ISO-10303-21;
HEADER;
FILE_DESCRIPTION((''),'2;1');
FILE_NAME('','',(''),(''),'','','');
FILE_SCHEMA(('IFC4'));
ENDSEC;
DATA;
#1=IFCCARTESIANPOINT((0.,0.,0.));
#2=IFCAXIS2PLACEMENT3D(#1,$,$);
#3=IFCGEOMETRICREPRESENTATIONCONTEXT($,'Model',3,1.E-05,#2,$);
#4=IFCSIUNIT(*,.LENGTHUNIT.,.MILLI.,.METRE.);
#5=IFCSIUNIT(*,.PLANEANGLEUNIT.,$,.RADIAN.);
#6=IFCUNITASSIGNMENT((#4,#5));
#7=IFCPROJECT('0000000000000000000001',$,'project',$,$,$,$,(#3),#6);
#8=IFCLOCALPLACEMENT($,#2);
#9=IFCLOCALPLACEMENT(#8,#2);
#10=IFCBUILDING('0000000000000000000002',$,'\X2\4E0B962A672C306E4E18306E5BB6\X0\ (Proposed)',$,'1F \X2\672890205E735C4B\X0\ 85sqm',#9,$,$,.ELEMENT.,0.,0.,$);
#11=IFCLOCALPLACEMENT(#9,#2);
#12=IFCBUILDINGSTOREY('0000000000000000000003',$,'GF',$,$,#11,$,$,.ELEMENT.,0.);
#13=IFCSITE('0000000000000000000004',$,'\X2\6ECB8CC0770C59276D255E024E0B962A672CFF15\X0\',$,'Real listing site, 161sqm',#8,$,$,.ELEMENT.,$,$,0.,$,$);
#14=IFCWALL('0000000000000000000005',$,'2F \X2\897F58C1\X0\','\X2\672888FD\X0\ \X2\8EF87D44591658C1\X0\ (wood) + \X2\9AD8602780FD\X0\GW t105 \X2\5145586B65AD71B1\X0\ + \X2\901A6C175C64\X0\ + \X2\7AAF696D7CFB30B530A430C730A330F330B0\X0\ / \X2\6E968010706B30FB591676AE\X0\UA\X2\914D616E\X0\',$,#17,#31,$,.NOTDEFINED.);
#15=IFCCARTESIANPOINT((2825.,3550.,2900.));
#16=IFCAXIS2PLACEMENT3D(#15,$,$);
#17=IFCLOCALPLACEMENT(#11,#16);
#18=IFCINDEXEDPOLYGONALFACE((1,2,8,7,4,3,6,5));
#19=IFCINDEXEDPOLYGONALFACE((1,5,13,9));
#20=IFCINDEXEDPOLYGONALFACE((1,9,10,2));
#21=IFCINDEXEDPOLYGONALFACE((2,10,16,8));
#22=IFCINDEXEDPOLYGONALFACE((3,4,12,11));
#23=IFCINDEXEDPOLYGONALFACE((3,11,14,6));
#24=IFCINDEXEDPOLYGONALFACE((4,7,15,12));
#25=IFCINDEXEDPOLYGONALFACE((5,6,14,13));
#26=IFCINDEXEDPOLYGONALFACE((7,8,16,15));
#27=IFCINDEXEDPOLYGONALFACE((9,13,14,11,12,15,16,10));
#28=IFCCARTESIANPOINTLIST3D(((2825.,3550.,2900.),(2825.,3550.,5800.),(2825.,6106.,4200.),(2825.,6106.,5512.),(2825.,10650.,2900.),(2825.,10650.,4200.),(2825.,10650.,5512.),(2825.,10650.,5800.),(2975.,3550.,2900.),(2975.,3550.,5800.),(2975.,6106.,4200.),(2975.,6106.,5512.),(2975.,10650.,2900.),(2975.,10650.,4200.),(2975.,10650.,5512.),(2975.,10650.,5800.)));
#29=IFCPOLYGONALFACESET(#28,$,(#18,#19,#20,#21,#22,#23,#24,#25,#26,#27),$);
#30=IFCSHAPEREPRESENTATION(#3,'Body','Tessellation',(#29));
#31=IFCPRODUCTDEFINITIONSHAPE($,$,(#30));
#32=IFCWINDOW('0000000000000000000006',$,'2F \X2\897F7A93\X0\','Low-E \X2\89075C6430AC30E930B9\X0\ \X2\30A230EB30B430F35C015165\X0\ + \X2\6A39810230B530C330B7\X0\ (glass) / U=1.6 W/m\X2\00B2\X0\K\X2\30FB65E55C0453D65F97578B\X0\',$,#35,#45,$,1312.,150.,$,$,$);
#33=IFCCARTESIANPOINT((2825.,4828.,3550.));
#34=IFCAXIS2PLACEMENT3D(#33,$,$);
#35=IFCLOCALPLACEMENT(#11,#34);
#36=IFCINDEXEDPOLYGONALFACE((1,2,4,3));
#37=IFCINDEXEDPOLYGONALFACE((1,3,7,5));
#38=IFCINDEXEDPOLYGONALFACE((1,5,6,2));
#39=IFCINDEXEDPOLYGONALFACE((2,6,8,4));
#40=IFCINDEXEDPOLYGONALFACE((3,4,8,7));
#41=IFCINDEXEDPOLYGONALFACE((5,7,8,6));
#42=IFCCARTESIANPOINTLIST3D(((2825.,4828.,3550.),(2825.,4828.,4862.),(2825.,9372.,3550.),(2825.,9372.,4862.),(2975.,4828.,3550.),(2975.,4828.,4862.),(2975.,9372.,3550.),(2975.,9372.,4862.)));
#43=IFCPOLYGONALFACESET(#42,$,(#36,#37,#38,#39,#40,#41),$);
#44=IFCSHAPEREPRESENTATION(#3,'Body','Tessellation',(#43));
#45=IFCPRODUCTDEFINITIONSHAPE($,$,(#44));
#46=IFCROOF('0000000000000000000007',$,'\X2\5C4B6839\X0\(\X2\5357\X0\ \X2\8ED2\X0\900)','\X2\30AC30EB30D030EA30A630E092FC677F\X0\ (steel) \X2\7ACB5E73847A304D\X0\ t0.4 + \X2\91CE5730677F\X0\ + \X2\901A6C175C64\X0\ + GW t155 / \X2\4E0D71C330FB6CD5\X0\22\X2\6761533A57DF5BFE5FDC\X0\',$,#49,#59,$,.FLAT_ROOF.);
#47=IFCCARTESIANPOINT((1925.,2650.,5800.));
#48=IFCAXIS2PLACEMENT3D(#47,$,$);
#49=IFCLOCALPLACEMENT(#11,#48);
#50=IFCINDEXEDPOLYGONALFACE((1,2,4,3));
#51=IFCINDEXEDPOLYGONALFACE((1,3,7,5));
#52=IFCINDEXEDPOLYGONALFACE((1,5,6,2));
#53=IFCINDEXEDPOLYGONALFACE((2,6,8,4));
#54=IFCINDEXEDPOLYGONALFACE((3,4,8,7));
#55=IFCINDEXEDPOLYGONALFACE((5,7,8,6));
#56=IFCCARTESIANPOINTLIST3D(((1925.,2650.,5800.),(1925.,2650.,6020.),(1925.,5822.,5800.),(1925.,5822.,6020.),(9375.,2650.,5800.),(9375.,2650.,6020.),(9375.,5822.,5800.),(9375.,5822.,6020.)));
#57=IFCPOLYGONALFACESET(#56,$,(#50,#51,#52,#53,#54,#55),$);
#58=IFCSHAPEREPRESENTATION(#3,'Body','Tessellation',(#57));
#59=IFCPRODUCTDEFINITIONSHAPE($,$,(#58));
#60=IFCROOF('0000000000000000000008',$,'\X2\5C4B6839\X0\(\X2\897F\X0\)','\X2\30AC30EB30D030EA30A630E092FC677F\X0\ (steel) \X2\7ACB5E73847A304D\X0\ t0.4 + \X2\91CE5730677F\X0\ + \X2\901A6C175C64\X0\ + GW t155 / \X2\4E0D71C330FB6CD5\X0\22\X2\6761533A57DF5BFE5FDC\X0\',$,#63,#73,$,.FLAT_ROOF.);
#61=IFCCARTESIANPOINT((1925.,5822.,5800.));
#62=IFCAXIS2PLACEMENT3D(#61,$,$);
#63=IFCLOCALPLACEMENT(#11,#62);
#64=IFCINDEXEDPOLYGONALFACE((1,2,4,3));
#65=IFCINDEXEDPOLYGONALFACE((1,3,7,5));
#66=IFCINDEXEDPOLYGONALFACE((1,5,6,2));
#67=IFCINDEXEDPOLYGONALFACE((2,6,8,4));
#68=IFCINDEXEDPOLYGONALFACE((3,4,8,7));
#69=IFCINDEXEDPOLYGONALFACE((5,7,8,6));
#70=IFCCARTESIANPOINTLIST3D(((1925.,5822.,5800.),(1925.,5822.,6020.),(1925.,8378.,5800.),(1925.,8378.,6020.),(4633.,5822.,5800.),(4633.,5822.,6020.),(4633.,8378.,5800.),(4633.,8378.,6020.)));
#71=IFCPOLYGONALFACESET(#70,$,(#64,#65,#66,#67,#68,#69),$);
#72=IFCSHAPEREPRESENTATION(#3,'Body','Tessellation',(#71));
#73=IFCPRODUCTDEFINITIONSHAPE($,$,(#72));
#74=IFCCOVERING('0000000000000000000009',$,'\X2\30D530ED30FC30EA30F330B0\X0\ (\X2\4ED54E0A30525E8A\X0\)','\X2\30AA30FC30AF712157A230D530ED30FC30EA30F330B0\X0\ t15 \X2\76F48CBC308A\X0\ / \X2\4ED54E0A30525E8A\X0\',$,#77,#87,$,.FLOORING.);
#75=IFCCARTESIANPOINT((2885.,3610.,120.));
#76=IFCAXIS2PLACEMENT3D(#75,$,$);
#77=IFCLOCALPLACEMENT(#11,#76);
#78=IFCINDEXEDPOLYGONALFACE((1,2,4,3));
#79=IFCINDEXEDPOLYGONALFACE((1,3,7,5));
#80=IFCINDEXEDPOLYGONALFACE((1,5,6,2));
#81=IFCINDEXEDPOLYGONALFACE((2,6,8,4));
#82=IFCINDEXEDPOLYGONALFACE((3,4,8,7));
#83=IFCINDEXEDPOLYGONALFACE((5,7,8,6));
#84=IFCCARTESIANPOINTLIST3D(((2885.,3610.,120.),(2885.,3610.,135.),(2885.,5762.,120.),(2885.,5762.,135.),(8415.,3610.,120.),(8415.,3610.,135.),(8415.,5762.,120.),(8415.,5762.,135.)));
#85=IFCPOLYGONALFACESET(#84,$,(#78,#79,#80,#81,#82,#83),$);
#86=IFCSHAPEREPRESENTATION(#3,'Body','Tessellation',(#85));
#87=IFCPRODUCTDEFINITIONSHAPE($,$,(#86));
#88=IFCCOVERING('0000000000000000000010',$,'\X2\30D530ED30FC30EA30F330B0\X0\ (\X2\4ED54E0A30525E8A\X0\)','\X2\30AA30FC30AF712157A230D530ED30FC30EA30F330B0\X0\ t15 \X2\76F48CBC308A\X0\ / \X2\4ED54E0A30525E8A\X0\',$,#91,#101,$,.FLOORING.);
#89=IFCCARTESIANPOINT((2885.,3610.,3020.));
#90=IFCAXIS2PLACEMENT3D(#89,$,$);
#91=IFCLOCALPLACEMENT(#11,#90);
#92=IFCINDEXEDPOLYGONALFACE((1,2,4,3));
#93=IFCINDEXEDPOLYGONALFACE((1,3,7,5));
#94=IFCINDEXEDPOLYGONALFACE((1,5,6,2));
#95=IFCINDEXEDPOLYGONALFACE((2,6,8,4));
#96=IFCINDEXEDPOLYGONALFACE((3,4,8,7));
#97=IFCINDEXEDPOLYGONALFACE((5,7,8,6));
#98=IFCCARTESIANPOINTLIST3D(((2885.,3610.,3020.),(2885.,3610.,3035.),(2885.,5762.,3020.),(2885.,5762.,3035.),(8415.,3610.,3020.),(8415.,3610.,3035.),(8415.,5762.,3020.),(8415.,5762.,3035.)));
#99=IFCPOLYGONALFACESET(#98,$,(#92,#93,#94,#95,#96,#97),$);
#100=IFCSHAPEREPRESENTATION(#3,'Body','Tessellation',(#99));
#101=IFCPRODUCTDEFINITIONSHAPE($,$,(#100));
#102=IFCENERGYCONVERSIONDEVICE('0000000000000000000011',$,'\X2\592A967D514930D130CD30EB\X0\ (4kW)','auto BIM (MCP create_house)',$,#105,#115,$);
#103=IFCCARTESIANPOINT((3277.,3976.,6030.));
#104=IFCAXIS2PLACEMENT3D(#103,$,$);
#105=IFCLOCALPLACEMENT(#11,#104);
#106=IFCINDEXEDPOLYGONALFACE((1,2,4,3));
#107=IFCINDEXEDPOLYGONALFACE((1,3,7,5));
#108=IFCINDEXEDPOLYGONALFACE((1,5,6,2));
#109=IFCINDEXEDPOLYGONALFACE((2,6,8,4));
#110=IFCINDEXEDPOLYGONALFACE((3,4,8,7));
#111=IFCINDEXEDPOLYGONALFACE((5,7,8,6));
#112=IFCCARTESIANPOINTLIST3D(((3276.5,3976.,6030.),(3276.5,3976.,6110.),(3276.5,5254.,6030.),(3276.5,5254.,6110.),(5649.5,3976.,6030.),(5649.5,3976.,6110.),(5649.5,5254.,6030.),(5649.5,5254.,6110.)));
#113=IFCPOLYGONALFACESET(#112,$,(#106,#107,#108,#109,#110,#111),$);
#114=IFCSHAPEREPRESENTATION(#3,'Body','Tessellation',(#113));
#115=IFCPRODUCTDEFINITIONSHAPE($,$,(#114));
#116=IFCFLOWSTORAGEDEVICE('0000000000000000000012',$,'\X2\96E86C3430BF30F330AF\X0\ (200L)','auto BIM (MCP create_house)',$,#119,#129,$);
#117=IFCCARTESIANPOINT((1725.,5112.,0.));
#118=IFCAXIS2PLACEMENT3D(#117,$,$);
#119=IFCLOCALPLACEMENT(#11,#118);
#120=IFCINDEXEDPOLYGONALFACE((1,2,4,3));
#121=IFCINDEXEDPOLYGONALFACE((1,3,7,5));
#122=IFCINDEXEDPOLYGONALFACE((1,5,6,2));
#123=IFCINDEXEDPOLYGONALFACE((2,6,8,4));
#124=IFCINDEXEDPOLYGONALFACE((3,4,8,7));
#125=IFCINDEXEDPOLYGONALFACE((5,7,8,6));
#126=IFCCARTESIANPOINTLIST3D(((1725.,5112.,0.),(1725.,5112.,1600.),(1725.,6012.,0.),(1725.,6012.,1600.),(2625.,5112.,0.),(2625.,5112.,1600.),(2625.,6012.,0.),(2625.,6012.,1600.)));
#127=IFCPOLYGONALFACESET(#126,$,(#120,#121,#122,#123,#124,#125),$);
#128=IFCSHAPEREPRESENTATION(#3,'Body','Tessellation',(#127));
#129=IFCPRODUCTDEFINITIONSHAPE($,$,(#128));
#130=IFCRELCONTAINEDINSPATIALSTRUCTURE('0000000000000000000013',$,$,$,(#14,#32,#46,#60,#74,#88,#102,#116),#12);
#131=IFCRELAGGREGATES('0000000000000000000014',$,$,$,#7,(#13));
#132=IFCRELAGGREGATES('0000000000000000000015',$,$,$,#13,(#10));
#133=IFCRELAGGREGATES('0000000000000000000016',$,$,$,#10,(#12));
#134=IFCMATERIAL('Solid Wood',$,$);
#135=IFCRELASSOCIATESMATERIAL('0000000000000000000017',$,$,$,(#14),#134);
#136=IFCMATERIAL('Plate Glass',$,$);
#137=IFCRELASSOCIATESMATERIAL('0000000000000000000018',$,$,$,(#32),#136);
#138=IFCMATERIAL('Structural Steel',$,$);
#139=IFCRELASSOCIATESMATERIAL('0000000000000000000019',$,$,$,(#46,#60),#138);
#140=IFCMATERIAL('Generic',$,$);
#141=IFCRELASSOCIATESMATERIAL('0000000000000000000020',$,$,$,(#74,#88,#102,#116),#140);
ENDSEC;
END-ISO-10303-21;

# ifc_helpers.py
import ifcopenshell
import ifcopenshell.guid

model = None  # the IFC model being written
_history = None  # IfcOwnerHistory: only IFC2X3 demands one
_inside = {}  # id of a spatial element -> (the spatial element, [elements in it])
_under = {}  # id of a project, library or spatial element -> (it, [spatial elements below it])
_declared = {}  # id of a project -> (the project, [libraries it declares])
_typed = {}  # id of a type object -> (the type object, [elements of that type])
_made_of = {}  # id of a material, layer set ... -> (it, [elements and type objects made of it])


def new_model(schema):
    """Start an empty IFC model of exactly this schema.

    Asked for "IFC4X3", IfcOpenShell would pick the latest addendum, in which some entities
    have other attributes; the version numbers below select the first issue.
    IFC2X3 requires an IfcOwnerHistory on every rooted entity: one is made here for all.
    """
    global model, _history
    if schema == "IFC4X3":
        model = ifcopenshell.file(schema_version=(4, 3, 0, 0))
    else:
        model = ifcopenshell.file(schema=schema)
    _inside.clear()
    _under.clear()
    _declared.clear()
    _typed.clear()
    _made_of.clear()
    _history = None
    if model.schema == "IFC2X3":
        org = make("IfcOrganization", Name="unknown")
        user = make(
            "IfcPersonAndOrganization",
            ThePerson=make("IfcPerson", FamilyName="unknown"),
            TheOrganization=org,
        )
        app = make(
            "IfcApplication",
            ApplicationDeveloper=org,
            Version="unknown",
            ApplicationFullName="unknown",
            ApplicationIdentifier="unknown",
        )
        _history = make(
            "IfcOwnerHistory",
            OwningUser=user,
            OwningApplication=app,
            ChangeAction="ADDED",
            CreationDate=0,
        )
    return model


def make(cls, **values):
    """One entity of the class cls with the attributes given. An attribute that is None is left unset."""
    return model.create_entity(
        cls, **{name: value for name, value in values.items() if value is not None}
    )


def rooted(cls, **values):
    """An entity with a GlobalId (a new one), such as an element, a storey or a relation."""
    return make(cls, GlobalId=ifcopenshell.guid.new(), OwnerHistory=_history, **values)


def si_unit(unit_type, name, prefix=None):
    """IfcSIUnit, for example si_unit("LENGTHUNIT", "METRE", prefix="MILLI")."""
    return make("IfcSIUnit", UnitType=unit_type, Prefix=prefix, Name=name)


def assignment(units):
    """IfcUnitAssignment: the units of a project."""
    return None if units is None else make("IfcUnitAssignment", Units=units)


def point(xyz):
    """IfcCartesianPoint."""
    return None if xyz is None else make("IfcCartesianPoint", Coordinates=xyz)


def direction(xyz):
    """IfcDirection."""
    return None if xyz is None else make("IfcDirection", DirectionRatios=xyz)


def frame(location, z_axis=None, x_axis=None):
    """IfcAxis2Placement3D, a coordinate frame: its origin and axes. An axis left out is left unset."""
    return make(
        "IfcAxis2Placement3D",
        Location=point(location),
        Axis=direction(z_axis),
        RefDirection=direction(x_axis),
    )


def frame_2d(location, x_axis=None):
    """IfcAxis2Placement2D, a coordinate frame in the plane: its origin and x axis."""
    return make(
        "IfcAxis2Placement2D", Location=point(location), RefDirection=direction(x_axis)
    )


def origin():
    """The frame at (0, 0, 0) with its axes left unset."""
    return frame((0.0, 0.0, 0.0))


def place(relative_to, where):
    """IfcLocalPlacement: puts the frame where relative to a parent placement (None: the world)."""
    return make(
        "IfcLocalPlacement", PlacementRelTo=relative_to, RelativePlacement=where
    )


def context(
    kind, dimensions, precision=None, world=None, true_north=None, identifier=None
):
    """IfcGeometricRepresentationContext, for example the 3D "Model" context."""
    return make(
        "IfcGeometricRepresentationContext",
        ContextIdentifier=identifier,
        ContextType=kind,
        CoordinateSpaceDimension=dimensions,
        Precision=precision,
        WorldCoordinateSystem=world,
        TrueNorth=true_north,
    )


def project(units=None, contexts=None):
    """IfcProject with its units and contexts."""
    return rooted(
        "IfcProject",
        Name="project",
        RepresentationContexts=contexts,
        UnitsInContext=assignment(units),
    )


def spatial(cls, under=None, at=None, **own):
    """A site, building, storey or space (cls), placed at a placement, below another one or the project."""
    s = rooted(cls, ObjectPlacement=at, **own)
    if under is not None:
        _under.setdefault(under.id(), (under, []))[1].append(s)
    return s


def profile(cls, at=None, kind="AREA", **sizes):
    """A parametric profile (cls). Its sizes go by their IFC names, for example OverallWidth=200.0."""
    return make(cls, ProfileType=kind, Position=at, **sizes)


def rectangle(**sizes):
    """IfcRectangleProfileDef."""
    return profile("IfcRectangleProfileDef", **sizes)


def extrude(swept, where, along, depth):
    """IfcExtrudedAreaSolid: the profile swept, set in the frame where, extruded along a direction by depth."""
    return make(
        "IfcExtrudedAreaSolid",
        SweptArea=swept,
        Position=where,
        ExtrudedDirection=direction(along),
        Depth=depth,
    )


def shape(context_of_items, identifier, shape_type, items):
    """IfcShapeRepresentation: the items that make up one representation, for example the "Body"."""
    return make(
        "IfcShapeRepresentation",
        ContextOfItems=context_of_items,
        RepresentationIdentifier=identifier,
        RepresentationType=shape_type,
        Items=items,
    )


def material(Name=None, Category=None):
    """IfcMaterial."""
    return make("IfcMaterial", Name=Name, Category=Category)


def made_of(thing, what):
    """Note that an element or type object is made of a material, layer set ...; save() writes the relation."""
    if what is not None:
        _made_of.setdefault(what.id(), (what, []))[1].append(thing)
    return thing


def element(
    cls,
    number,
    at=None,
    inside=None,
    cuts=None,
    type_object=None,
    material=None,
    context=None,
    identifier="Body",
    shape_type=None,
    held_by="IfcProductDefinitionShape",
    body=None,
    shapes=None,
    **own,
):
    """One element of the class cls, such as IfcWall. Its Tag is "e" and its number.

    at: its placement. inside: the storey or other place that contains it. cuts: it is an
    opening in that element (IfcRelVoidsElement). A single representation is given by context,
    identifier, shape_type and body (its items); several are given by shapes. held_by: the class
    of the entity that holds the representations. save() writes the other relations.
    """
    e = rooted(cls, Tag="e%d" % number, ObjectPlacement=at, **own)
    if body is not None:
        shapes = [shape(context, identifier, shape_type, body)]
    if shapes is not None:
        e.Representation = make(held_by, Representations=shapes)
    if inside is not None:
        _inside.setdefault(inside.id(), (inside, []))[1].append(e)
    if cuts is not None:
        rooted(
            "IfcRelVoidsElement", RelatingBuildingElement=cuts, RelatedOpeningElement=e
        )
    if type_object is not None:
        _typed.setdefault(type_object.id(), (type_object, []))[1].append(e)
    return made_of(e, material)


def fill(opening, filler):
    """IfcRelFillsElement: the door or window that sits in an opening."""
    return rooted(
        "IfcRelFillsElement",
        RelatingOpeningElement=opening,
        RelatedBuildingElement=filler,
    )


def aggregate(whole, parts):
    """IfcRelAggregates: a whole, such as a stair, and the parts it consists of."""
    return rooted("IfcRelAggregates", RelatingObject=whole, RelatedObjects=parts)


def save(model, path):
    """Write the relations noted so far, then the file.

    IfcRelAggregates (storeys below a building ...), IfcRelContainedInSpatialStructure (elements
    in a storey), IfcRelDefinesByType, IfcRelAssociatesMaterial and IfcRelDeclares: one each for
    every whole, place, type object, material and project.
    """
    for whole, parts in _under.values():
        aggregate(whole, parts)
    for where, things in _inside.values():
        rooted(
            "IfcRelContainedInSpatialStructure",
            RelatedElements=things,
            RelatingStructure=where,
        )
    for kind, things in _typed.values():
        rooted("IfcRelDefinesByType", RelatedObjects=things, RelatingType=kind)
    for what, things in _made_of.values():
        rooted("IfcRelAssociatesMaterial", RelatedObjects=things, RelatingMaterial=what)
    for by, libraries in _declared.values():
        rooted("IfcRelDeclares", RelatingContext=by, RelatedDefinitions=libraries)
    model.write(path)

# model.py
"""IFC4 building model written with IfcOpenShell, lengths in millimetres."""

from ifc_helpers import new_model, si_unit, frame, frame_2d, origin, place, context, project, spatial, rectangle, extrude, material, element, fill, save


model = new_model("IFC4")

# Units and contexts
model_context = context("Model", 3, precision=1e-05, world=origin())
ifc_project = project(units=[si_unit("LENGTHUNIT", "METRE", prefix="MILLI"), si_unit("PLANEANGLEUNIT", "RADIAN")], contexts=[model_context])

# Site, building, storey
site_placement = place(None, origin())
site = spatial("IfcSite", under=ifc_project, at=site_placement, Name="滋賀県大津市下阪本５", ObjectType="Real listing site, 161sqm", CompositionType="ELEMENT", RefElevation=0.0)
building_placement = place(site_placement, origin())
building = spatial("IfcBuilding", under=site, at=building_placement, Name="下阪本の丘の家 (Proposed)", ObjectType="1F 木造平屋 85sqm", CompositionType="ELEMENT", ElevationOfRefHeight=0.0, ElevationOfTerrain=0.0)
storey_placement = place(building_placement, origin())
storey = spatial("IfcBuildingStorey", under=building, at=storey_placement, Name="GF", CompositionType="ELEMENT", Elevation=0.0)

# Shared definitions
ifc_material_1 = material(Name="Solid Wood")
ifc_material_2 = material(Name="Generic")

# Shared definitions
ifc_material_3 = material(Name="Plate Glass")

# Wall, opening, window
wall_1_placement = place(storey_placement, frame((2825.0, 3550.0, 2900.0)))
wall_1 = element("IfcWall", 1, at=wall_1_placement, inside=storey, material=ifc_material_1, Name="2F 西壁", Description="木製 軸組外壁 (wood) + 高性能GW t105 充填断熱 + 通気層 + 窯業系サイディング / 準耐火・外皮UA配慮", PredefinedType="NOTDEFINED", context=model_context, shape_type="SweptSolid", body=[
    extrude(rectangle(XDim=150.0, YDim=7100.0, at=frame_2d((75.0, 3550.0))), frame((2825.0, 3550.0, 2900.0)), (0.0, 0.0, 1.0), 2900.0),
])
opening_1_placement = place(storey_placement, frame((2825.0, 4828.0, 3550.0)))
opening_1 = element("IfcOpeningElement", 2, at=opening_1_placement, cuts=wall_1, PredefinedType="NOTDEFINED", context=model_context, shape_type="SweptSolid", body=[
    extrude(rectangle(XDim=150.0, YDim=4544.0, at=frame_2d((75.0, 2272.0))), frame((2825.0, 4828.0, 3550.0)), (0.0, 0.0, 1.0), 1312.0),
])
window_1_placement = place(storey_placement, frame((2825.0, 4828.0, 3550.0)))
window_1 = element("IfcWindow", 3, at=window_1_placement, inside=storey, material=ifc_material_3, Name="2F 西窓", Description="Low-E 複層ガラス アルゴン封入 + 樹脂サッシ (glass) / U=1.6 W/m²K・日射取得型", OverallHeight=1312.0, OverallWidth=150.0, context=model_context, shape_type="SweptSolid", body=[
    extrude(rectangle(XDim=150.0, YDim=4544.0, at=frame_2d((75.0, 2272.0))), frame((2825.0, 4828.0, 3550.0)), (0.0, 0.0, 1.0), 1312.0),
])
fill(opening_1, window_1)

# Roofs
ifc_material_4 = material(Name="Structural Steel")
roof_1_placement = place(storey_placement, frame((1925.0, 2650.0, 5800.0)))
element("IfcRoof", 4, at=roof_1_placement, inside=storey, material=ifc_material_4, Name="屋根(南 軒900)", Description="ガルバリウム鋼板 (steel) 立平葺き t0.4 + 野地板 + 通気層 + GW t155 / 不燃・法22条区域対応", PredefinedType="FLAT_ROOF", context=model_context, shape_type="SweptSolid", body=[
    extrude(rectangle(XDim=7450.0, YDim=3172.0, at=frame_2d((3725.0, 1586.0))), frame((1925.0, 2650.0, 5800.0)), (0.0, 0.0, 1.0), 220.0),
])
roof_2_placement = place(storey_placement, frame((1925.0, 5822.0, 5800.0)))
element("IfcRoof", 5, at=roof_2_placement, inside=storey, material=ifc_material_4, Name="屋根(西)", Description="ガルバリウム鋼板 (steel) 立平葺き t0.4 + 野地板 + 通気層 + GW t155 / 不燃・法22条区域対応", PredefinedType="FLAT_ROOF", context=model_context, shape_type="SweptSolid", body=[
    extrude(rectangle(XDim=2708.0, YDim=2556.0, at=frame_2d((1354.0, 1278.0))), frame((1925.0, 5822.0, 5800.0)), (0.0, 0.0, 1.0), 220.0),
])

# Coverings
covering_1_placement = place(storey_placement, frame((2885.0, 3610.0, 120.0)))
element("IfcCovering", 6, at=covering_1_placement, inside=storey, material=ifc_material_2, Name="フローリング (仕上げ床)", Description="オーク無垢フローリング t15 直貼り / 仕上げ床", PredefinedType="FLOORING", context=model_context, shape_type="SweptSolid", body=[
    extrude(rectangle(XDim=5530.0, YDim=2152.0, at=frame_2d((2765.0, 1076.0))), frame((2885.0, 3610.0, 120.0)), (0.0, 0.0, 1.0), 15.0),
])
covering_2_placement = place(storey_placement, frame((2885.0, 3610.0, 3020.0)))
element("IfcCovering", 7, at=covering_2_placement, inside=storey, material=ifc_material_2, Name="フローリング (仕上げ床)", Description="オーク無垢フローリング t15 直貼り / 仕上げ床", PredefinedType="FLOORING", context=model_context, shape_type="SweptSolid", body=[
    extrude(rectangle(XDim=5530.0, YDim=2152.0, at=frame_2d((2765.0, 1076.0))), frame((2885.0, 3610.0, 3020.0)), (0.0, 0.0, 1.0), 15.0),
])

# Energy conversion device
energy_conversion_device_placement = place(storey_placement, frame((3277.0, 3976.0, 6030.0)))
element("IfcEnergyConversionDevice", 8, at=energy_conversion_device_placement, inside=storey, material=ifc_material_2, Name="太陽光パネル (4kW)", Description="auto BIM (MCP create_house)", context=model_context, shape_type="SweptSolid", body=[
    extrude(rectangle(XDim=2373.0, YDim=1278.0, at=frame_2d((1186.0, 639.0))), frame((3277.0, 3976.0, 6030.0)), (0.0, 0.0, 1.0), 80.0),
])

# Flow storage device
flow_storage_device_placement = place(storey_placement, frame((1725.0, 5112.0, 0.0)))
element("IfcFlowStorageDevice", 9, at=flow_storage_device_placement, inside=storey, material=ifc_material_2, Name="雨水タンク (200L)", Description="auto BIM (MCP create_house)", context=model_context, shape_type="SweptSolid", body=[
    extrude(rectangle(XDim=900.0, YDim=900.0, at=frame_2d((450.0, 450.0))), frame((1725.0, 5112.0, 0.0)), (0.0, 0.0, 1.0), 1600.0),
])

save(model, "model.ifc")
